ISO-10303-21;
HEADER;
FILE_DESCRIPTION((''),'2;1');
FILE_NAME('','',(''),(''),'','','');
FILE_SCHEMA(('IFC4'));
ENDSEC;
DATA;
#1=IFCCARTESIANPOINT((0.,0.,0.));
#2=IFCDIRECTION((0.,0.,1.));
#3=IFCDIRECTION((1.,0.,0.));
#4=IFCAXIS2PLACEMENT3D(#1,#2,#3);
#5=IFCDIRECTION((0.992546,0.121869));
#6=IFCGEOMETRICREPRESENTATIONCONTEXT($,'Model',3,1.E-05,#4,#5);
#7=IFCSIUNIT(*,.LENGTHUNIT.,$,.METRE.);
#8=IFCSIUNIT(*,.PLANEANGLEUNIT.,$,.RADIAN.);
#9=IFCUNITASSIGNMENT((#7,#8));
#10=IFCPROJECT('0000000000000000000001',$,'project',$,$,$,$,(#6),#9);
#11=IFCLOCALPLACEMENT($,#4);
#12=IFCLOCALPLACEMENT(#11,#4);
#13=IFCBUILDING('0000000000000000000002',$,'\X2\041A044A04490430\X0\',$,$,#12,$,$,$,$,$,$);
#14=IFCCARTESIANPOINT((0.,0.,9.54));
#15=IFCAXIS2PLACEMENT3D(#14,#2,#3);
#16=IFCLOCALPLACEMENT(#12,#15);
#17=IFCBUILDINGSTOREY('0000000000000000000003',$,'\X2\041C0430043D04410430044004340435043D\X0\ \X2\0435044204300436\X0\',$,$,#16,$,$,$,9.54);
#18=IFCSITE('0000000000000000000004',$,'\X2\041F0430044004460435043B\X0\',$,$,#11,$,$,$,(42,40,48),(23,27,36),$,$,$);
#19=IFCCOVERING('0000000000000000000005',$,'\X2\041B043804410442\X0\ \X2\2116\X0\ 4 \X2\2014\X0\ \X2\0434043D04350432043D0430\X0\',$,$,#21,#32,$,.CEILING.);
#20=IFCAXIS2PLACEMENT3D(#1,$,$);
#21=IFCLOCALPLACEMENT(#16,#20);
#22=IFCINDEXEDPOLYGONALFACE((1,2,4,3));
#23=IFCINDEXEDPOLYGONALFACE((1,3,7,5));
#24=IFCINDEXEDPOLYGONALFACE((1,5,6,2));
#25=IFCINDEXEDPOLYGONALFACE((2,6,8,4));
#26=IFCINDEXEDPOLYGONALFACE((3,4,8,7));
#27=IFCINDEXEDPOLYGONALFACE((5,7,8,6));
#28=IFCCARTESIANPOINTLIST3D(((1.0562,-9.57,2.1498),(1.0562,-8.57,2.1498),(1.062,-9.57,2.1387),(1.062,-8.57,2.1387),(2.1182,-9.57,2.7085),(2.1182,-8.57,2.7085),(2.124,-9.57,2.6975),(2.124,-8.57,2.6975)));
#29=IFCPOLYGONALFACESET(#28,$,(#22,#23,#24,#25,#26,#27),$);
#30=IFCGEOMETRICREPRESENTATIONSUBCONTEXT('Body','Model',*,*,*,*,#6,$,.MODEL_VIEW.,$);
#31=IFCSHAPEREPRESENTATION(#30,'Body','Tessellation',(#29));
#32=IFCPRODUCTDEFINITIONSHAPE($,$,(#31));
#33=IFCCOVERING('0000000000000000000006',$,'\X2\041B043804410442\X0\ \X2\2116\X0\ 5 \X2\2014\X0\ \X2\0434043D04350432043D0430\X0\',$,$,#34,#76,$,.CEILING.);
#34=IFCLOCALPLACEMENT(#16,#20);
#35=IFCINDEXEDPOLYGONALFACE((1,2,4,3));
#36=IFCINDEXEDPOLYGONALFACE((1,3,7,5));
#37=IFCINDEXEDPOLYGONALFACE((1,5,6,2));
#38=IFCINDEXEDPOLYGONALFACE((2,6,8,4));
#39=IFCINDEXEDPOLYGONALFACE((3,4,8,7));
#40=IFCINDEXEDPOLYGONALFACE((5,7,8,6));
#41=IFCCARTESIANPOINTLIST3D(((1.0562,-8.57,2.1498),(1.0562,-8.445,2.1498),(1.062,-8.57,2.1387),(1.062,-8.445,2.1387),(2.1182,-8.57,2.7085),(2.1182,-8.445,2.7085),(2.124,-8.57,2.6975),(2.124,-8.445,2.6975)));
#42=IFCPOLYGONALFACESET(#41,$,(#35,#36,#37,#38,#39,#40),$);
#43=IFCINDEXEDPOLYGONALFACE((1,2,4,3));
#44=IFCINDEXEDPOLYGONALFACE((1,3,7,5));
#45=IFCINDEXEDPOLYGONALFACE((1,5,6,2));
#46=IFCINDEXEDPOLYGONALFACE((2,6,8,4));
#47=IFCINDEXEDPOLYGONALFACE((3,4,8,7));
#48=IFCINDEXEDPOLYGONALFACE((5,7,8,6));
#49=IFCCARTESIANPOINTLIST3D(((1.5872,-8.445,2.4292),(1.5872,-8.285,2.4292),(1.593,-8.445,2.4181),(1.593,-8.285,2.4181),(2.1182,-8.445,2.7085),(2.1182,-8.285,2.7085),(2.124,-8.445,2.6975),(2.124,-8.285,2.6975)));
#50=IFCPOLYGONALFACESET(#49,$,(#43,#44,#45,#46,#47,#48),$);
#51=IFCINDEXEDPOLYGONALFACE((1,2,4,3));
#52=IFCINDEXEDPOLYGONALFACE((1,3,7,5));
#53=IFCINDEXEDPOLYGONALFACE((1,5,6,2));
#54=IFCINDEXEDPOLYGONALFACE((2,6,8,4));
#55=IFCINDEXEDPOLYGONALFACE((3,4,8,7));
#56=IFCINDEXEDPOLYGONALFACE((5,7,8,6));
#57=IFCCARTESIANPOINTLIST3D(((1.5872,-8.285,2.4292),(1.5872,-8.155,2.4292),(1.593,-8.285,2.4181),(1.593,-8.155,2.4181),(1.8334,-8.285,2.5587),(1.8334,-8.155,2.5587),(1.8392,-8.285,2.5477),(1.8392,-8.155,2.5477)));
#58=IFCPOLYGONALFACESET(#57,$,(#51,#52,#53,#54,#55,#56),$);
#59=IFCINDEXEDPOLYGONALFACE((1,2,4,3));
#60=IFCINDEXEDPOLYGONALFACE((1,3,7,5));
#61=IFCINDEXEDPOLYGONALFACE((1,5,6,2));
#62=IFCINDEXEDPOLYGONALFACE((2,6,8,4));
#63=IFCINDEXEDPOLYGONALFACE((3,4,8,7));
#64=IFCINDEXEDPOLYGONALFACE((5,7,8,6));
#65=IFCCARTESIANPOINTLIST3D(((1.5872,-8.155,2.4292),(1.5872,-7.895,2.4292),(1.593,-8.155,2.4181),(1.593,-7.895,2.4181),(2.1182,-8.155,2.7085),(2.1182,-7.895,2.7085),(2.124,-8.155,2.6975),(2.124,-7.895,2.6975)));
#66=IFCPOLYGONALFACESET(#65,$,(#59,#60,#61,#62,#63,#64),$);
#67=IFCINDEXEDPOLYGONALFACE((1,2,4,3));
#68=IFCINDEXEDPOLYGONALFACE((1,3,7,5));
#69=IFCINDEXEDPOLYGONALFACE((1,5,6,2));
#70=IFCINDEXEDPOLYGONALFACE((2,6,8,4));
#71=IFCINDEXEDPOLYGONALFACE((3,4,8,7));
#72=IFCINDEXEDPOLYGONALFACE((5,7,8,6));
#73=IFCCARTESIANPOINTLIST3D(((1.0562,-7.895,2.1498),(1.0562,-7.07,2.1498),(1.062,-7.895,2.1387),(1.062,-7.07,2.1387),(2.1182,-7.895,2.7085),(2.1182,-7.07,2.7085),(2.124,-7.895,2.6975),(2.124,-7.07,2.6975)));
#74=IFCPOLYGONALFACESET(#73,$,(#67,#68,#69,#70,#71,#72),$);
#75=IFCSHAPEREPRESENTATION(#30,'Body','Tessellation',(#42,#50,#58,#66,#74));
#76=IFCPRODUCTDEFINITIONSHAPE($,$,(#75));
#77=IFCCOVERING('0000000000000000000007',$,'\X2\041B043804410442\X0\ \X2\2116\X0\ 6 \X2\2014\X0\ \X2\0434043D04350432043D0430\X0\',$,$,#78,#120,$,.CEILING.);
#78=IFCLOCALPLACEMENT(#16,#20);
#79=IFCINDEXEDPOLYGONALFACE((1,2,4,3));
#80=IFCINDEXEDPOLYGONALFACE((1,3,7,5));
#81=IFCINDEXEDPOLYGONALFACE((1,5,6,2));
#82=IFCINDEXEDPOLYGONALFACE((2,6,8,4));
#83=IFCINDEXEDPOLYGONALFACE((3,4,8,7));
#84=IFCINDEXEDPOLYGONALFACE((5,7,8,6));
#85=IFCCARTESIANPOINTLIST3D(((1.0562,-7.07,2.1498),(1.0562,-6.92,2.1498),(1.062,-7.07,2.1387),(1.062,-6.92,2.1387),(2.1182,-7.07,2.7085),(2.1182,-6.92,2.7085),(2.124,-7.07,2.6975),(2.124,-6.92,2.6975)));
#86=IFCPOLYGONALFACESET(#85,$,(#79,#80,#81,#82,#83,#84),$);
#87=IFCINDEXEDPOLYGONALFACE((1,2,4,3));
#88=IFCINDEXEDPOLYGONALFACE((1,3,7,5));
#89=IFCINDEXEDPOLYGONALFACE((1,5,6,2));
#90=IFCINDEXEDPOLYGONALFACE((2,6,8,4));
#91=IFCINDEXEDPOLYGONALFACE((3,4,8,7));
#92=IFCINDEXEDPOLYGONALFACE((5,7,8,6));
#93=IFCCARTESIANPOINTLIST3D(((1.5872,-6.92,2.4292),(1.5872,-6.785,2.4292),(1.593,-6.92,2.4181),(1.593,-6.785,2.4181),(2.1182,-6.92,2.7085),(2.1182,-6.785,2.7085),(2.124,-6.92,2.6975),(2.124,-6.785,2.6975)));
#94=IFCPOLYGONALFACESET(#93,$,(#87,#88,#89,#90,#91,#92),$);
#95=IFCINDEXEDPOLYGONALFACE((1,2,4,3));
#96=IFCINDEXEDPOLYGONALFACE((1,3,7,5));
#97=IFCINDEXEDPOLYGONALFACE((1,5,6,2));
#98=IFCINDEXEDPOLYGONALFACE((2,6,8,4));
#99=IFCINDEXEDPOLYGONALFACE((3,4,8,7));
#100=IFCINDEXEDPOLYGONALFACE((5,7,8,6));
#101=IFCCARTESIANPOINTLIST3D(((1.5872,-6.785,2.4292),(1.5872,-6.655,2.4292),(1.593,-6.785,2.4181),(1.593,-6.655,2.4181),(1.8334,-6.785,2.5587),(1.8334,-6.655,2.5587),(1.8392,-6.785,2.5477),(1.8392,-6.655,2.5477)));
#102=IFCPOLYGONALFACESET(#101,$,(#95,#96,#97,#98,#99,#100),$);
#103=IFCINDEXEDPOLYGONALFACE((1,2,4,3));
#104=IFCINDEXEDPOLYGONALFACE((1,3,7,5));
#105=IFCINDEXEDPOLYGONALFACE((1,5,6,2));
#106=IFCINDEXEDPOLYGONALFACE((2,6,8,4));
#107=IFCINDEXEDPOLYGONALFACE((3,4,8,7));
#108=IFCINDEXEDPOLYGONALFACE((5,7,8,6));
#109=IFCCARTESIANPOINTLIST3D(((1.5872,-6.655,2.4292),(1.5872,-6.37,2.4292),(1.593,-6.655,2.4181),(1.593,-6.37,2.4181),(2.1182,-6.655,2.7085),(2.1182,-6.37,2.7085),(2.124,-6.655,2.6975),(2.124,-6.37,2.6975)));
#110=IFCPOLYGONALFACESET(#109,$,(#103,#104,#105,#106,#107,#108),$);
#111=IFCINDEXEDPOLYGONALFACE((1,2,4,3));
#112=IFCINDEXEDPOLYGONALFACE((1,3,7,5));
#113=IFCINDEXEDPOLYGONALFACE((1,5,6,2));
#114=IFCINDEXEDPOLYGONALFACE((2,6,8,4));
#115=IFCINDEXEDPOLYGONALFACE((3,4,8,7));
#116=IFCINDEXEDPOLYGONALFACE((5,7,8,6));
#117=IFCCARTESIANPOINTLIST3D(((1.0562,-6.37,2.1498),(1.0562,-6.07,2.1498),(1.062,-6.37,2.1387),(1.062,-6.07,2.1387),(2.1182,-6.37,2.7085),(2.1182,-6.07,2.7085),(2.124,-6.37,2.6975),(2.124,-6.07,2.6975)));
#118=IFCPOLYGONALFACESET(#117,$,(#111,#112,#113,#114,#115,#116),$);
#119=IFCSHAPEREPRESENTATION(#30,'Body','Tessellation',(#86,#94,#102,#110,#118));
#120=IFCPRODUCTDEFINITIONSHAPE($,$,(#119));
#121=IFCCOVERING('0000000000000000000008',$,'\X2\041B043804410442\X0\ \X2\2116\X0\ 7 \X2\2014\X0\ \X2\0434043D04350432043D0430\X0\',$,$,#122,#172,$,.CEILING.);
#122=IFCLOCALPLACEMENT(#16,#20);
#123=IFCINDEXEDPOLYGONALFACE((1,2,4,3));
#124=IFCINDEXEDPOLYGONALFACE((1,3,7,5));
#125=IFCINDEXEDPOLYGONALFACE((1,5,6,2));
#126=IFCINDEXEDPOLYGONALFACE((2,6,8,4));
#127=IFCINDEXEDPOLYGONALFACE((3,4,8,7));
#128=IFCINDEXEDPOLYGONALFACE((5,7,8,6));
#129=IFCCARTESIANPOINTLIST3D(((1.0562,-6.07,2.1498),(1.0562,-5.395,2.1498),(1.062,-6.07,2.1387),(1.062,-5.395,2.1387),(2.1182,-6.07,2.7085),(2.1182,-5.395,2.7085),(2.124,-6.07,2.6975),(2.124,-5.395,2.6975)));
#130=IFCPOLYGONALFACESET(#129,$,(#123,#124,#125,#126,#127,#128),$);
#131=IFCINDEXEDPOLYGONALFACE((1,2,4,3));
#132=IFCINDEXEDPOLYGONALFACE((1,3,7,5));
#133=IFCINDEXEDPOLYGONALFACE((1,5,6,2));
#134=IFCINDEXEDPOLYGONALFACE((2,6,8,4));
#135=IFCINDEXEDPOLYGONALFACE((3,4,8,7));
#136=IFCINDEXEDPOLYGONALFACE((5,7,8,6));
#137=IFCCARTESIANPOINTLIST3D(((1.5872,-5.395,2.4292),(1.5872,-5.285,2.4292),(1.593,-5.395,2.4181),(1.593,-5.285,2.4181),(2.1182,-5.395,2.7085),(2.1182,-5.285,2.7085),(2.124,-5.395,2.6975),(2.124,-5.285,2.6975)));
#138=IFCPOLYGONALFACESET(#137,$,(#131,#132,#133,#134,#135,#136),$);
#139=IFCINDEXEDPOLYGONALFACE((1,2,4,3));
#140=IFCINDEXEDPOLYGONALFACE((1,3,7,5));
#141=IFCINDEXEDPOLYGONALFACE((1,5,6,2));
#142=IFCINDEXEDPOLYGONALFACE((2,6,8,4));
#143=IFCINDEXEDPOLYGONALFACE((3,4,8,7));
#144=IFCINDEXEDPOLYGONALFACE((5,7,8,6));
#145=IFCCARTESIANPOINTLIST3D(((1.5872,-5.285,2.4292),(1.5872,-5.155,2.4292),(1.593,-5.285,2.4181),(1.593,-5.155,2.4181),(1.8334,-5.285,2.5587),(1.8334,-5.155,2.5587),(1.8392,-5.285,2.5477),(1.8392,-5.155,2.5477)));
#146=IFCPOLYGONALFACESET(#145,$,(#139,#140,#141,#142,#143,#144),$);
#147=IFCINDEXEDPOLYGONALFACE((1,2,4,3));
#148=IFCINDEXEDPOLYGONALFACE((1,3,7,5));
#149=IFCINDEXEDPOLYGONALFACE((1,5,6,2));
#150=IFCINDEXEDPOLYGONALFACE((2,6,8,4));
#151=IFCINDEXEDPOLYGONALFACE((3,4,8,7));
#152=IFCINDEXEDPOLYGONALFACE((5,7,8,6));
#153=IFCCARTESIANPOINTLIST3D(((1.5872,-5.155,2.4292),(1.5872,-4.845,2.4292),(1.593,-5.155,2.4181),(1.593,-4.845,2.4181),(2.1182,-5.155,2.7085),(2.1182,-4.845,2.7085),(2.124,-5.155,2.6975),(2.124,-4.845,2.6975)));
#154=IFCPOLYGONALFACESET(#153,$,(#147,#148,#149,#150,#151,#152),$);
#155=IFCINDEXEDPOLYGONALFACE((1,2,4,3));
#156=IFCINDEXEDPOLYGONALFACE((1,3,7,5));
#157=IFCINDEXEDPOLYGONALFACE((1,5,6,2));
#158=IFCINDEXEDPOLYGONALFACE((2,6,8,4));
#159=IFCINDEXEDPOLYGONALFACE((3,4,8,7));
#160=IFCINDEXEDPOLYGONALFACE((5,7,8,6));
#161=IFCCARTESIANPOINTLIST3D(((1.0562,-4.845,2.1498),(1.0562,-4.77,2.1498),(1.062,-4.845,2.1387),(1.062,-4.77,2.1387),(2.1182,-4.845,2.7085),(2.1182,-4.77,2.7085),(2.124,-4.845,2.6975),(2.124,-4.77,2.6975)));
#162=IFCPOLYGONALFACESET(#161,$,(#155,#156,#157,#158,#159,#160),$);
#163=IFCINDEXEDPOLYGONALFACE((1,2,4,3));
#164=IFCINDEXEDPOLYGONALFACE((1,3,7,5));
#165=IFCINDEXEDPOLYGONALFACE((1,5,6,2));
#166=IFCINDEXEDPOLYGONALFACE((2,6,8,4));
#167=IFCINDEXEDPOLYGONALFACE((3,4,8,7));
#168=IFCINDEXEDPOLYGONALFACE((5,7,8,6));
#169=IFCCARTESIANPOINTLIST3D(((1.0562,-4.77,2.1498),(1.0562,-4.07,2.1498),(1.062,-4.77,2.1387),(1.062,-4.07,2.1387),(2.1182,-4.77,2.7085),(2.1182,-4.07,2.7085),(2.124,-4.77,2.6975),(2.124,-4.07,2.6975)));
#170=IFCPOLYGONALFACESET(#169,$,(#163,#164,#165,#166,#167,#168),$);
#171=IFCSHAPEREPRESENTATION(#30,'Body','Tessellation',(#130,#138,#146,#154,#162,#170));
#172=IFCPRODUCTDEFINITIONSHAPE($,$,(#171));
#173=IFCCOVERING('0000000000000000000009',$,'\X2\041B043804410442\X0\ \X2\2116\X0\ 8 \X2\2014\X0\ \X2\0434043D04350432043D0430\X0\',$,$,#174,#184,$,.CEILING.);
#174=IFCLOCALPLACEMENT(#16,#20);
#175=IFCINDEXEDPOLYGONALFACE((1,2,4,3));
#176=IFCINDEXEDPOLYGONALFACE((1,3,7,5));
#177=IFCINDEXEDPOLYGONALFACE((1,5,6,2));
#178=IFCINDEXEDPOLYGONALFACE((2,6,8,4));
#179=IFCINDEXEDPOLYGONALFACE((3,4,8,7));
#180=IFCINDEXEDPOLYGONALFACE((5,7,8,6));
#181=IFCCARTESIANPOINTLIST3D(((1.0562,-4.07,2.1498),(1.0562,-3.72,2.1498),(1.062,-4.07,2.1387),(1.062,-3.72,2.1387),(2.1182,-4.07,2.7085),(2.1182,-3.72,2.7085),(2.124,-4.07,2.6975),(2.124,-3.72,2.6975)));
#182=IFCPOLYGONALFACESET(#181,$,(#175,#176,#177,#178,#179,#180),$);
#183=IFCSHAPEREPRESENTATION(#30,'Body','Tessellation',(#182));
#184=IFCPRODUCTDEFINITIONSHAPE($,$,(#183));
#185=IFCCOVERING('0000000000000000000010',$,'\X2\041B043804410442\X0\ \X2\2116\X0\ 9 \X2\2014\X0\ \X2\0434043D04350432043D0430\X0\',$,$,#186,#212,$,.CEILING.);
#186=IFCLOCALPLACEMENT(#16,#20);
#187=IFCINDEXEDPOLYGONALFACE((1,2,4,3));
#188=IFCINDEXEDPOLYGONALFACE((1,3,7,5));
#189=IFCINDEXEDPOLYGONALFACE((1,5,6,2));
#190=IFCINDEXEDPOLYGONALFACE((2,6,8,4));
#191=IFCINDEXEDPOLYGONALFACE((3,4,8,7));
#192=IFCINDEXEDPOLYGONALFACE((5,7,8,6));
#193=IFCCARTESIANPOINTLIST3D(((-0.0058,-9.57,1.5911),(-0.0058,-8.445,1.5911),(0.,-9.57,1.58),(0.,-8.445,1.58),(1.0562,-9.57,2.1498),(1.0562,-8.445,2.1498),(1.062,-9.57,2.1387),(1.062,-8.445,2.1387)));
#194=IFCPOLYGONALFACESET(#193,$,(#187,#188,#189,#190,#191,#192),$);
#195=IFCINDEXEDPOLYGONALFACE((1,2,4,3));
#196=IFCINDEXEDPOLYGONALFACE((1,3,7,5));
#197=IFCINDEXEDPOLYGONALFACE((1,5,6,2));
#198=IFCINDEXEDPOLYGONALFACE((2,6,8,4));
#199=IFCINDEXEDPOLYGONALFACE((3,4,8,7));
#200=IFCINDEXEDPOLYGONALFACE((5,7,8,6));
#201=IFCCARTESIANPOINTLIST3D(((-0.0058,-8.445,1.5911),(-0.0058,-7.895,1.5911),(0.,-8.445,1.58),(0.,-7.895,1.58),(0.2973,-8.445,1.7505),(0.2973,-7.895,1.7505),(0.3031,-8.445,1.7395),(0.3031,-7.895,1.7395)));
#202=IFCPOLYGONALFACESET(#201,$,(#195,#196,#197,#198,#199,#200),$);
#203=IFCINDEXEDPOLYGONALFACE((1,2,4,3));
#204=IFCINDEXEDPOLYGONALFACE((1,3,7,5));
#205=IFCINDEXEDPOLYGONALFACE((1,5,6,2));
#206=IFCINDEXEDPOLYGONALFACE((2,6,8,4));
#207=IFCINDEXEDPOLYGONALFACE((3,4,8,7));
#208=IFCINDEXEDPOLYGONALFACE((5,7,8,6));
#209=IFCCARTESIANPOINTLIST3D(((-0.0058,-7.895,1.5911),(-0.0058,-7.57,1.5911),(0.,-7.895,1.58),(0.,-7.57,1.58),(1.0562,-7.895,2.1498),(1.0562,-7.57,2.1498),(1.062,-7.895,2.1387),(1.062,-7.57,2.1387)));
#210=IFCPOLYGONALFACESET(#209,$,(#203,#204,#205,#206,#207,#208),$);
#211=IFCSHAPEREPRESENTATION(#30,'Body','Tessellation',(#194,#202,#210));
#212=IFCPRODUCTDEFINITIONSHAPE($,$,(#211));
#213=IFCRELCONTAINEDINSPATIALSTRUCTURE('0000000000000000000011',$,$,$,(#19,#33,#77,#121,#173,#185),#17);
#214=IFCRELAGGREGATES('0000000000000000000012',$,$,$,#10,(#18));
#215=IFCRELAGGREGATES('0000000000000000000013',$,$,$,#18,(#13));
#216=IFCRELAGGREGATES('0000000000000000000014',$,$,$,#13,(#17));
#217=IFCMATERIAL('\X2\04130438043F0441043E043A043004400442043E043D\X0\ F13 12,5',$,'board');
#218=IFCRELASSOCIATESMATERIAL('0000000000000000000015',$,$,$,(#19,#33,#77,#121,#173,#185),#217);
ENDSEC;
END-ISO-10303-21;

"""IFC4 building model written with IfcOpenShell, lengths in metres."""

from ifc_helpers import new_model, si_unit, direction, frame, origin_with_axes, place, context, subcontext, project, spatial, polyline, outline, extrude, material, element, save


model = new_model("IFC4")

# Units and contexts
model_context = context("Model", 3, precision=1e-05, world=origin_with_axes(), true_north=direction((0.992546, 0.121869)))
body_context = subcontext(model_context, "Body", "Model", "MODEL_VIEW")
ifc_project = project(units=[si_unit("LENGTHUNIT", "METRE"), si_unit("PLANEANGLEUNIT", "RADIAN")], contexts=[model_context])

# Site, building, storey
site_placement = place(None, origin_with_axes())
site = spatial("IfcSite", under=ifc_project, at=site_placement, Name="Парцел", RefLatitude=(42, 40, 48), RefLongitude=(23, 27, 36))
building_placement = place(site_placement, origin_with_axes())
building = spatial("IfcBuilding", under=site, at=building_placement, Name="Къща")
storey_placement = place(building_placement, frame((0.0, 0.0, 9.54), z_axis=(0.0, 0.0, 1.0), x_axis=(1.0, 0.0, 0.0)))
storey = spatial("IfcBuildingStorey", under=building, at=storey_placement, Name="Мансарден етаж", Elevation=9.54)

# Coverings
ifc_material_1 = material(Name="Гипсокартон F13 12,5", Category="board")
covering_1_placement = place(storey_placement, origin_with_axes())
element("IfcCovering", 1, at=covering_1_placement, inside=storey, material=ifc_material_1, Name="Лист № 4 — дневна", PredefinedType="CEILING", context=body_context, shape_type="SweptSolid", body=[
    extrude(outline(polyline([(1.062, -2.1387), (2.124, -2.6975), (2.1181, -2.7085), (1.0562, -2.1498), (1.062, -2.1387)])), frame((0.0, -9.57, 0.0), z_axis=(0.0, 1.0, 0.0), x_axis=(1.0, 0.0, 0.0)), (0.0, 0.0, 1.0), 1.0),
])
covering_2_placement = place(storey_placement, origin_with_axes())
element("IfcCovering", 2, at=covering_2_placement, inside=storey, material=ifc_material_1, Name="Лист № 5 — дневна", PredefinedType="CEILING", context=body_context, shape_type="SweptSolid", body=[
    extrude(outline(polyline([(1.062, -2.1387), (2.124, -2.6975), (2.1181, -2.7085), (1.0562, -2.1498), (1.062, -2.1387)])), frame((0.0, -8.57, 0.0), z_axis=(0.0, 1.0, 0.0), x_axis=(1.0, 0.0, 0.0)), (0.0, 0.0, 1.0), 0.125),
    extrude(outline(polyline([(1.593, -2.4181), (2.124, -2.6975), (2.1181, -2.7085), (1.5872, -2.4292), (1.593, -2.4181)])), frame((0.0, -8.445, 0.0), z_axis=(0.0, 1.0, 0.0), x_axis=(1.0, 0.0, 0.0)), (0.0, 0.0, 1.0), 0.16),
    extrude(outline(polyline([(1.593, -2.4181), (1.8392, -2.5477), (1.8334, -2.5587), (1.5872, -2.4292), (1.593, -2.4181)])), frame((0.0, -8.285, 0.0), z_axis=(0.0, 1.0, 0.0), x_axis=(1.0, 0.0, 0.0)), (0.0, 0.0, 1.0), 0.13),
    extrude(outline(polyline([(1.593, -2.4181), (2.124, -2.6975), (2.1181, -2.7085), (1.5872, -2.4292), (1.593, -2.4181)])), frame((0.0, -8.155, 0.0), z_axis=(0.0, 1.0, 0.0), x_axis=(1.0, 0.0, 0.0)), (0.0, 0.0, 1.0), 0.26),
    extrude(outline(polyline([(1.062, -2.1387), (2.124, -2.6975), (2.1181, -2.7085), (1.0562, -2.1498), (1.062, -2.1387)])), frame((0.0, -7.895, 0.0), z_axis=(0.0, 1.0, 0.0), x_axis=(1.0, 0.0, 0.0)), (0.0, 0.0, 1.0), 0.825),
])
covering_3_placement = place(storey_placement, origin_with_axes())
element("IfcCovering", 3, at=covering_3_placement, inside=storey, material=ifc_material_1, Name="Лист № 6 — дневна", PredefinedType="CEILING", context=body_context, shape_type="SweptSolid", body=[
    extrude(outline(polyline([(1.062, -2.1387), (2.124, -2.6975), (2.1181, -2.7085), (1.0562, -2.1498), (1.062, -2.1387)])), frame((0.0, -7.07, 0.0), z_axis=(0.0, 1.0, 0.0), x_axis=(1.0, 0.0, 0.0)), (0.0, 0.0, 1.0), 0.15),
    extrude(outline(polyline([(1.593, -2.4181), (2.124, -2.6975), (2.1181, -2.7085), (1.5872, -2.4292), (1.593, -2.4181)])), frame((0.0, -6.92, 0.0), z_axis=(0.0, 1.0, 0.0), x_axis=(1.0, 0.0, 0.0)), (0.0, 0.0, 1.0), 0.135),
    extrude(outline(polyline([(1.593, -2.4181), (1.8392, -2.5477), (1.8334, -2.5587), (1.5872, -2.4292), (1.593, -2.4181)])), frame((0.0, -6.785, 0.0), z_axis=(0.0, 1.0, 0.0), x_axis=(1.0, 0.0, 0.0)), (0.0, 0.0, 1.0), 0.13),
    extrude(outline(polyline([(1.593, -2.4181), (2.124, -2.6975), (2.1181, -2.7085), (1.5872, -2.4292), (1.593, -2.4181)])), frame((0.0, -6.655, 0.0), z_axis=(0.0, 1.0, 0.0), x_axis=(1.0, 0.0, 0.0)), (0.0, 0.0, 1.0), 0.285),
    extrude(outline(polyline([(1.062, -2.1387), (2.124, -2.6975), (2.1181, -2.7085), (1.0562, -2.1498), (1.062, -2.1387)])), frame((0.0, -6.37, 0.0), z_axis=(0.0, 1.0, 0.0), x_axis=(1.0, 0.0, 0.0)), (0.0, 0.0, 1.0), 0.3),
])
covering_4_placement = place(storey_placement, origin_with_axes())
element("IfcCovering", 4, at=covering_4_placement, inside=storey, material=ifc_material_1, Name="Лист № 7 — дневна", PredefinedType="CEILING", context=body_context, shape_type="SweptSolid", body=[
    extrude(outline(polyline([(1.062, -2.1387), (2.124, -2.6975), (2.1181, -2.7085), (1.0562, -2.1498), (1.062, -2.1387)])), frame((0.0, -6.07, 0.0), z_axis=(0.0, 1.0, 0.0), x_axis=(1.0, 0.0, 0.0)), (0.0, 0.0, 1.0), 0.675),
    extrude(outline(polyline([(1.593, -2.4181), (2.124, -2.6975), (2.1181, -2.7085), (1.5872, -2.4292), (1.593, -2.4181)])), frame((0.0, -5.395, 0.0), z_axis=(0.0, 1.0, 0.0), x_axis=(1.0, 0.0, 0.0)), (0.0, 0.0, 1.0), 0.11),
    extrude(outline(polyline([(1.593, -2.4181), (1.8392, -2.5477), (1.8334, -2.5587), (1.5872, -2.4292), (1.593, -2.4181)])), frame((0.0, -5.285, 0.0), z_axis=(0.0, 1.0, 0.0), x_axis=(1.0, 0.0, 0.0)), (0.0, 0.0, 1.0), 0.13),
    extrude(outline(polyline([(1.593, -2.4181), (2.124, -2.6975), (2.1181, -2.7085), (1.5872, -2.4292), (1.593, -2.4181)])), frame((0.0, -5.155, 0.0), z_axis=(0.0, 1.0, 0.0), x_axis=(1.0, 0.0, 0.0)), (0.0, 0.0, 1.0), 0.31),
    extrude(outline(polyline([(1.062, -2.1387), (2.124, -2.6975), (2.1181, -2.7085), (1.0562, -2.1498), (1.062, -2.1387)])), frame((0.0, -4.845, 0.0), z_axis=(0.0, 1.0, 0.0), x_axis=(1.0, 0.0, 0.0)), (0.0, 0.0, 1.0), 0.075),
    extrude(outline(polyline([(1.062, -2.1387), (2.124, -2.6975), (2.1181, -2.7085), (1.0562, -2.1498), (1.062, -2.1387)])), frame((0.0, -4.77, 0.0), z_axis=(0.0, 1.0, 0.0), x_axis=(1.0, 0.0, 0.0)), (0.0, 0.0, 1.0), 0.7),
])
covering_5_placement = place(storey_placement, origin_with_axes())
element("IfcCovering", 5, at=covering_5_placement, inside=storey, material=ifc_material_1, Name="Лист № 8 — дневна", PredefinedType="CEILING", context=body_context, shape_type="SweptSolid", body=[
    extrude(outline(polyline([(1.062, -2.1387), (2.124, -2.6975), (2.1181, -2.7085), (1.0562, -2.1498), (1.062, -2.1387)])), frame((0.0, -4.07, 0.0), z_axis=(0.0, 1.0, 0.0), x_axis=(1.0, 0.0, 0.0)), (0.0, 0.0, 1.0), 0.35),
])
covering_6_placement = place(storey_placement, origin_with_axes())
element("IfcCovering", 6, at=covering_6_placement, inside=storey, material=ifc_material_1, Name="Лист № 9 — дневна", PredefinedType="CEILING", context=body_context, shape_type="SweptSolid", body=[
    extrude(outline(polyline([(0.0, -1.58), (1.062, -2.1387), (1.0562, -2.1498), (-0.0058, -1.5911), (0.0, -1.58)])), frame((0.0, -9.57, 0.0), z_axis=(0.0, 1.0, 0.0), x_axis=(1.0, 0.0, 0.0)), (0.0, 0.0, 1.0), 1.125),
    extrude(outline(polyline([(0.0, -1.58), (0.3031, -1.7395), (0.2973, -1.7505), (-0.0058, -1.5911), (0.0, -1.58)])), frame((0.0, -8.445, 0.0), z_axis=(0.0, 1.0, 0.0), x_axis=(1.0, 0.0, 0.0)), (0.0, 0.0, 1.0), 0.55),
    extrude(outline(polyline([(0.0, -1.58), (1.062, -2.1387), (1.0562, -2.1498), (-0.0058, -1.5911), (0.0, -1.58)])), frame((0.0, -7.895, 0.0), z_axis=(0.0, 1.0, 0.0), x_axis=(1.0, 0.0, 0.0)), (0.0, 0.0, 1.0), 0.325),
])

save(model, "model.ifc")
